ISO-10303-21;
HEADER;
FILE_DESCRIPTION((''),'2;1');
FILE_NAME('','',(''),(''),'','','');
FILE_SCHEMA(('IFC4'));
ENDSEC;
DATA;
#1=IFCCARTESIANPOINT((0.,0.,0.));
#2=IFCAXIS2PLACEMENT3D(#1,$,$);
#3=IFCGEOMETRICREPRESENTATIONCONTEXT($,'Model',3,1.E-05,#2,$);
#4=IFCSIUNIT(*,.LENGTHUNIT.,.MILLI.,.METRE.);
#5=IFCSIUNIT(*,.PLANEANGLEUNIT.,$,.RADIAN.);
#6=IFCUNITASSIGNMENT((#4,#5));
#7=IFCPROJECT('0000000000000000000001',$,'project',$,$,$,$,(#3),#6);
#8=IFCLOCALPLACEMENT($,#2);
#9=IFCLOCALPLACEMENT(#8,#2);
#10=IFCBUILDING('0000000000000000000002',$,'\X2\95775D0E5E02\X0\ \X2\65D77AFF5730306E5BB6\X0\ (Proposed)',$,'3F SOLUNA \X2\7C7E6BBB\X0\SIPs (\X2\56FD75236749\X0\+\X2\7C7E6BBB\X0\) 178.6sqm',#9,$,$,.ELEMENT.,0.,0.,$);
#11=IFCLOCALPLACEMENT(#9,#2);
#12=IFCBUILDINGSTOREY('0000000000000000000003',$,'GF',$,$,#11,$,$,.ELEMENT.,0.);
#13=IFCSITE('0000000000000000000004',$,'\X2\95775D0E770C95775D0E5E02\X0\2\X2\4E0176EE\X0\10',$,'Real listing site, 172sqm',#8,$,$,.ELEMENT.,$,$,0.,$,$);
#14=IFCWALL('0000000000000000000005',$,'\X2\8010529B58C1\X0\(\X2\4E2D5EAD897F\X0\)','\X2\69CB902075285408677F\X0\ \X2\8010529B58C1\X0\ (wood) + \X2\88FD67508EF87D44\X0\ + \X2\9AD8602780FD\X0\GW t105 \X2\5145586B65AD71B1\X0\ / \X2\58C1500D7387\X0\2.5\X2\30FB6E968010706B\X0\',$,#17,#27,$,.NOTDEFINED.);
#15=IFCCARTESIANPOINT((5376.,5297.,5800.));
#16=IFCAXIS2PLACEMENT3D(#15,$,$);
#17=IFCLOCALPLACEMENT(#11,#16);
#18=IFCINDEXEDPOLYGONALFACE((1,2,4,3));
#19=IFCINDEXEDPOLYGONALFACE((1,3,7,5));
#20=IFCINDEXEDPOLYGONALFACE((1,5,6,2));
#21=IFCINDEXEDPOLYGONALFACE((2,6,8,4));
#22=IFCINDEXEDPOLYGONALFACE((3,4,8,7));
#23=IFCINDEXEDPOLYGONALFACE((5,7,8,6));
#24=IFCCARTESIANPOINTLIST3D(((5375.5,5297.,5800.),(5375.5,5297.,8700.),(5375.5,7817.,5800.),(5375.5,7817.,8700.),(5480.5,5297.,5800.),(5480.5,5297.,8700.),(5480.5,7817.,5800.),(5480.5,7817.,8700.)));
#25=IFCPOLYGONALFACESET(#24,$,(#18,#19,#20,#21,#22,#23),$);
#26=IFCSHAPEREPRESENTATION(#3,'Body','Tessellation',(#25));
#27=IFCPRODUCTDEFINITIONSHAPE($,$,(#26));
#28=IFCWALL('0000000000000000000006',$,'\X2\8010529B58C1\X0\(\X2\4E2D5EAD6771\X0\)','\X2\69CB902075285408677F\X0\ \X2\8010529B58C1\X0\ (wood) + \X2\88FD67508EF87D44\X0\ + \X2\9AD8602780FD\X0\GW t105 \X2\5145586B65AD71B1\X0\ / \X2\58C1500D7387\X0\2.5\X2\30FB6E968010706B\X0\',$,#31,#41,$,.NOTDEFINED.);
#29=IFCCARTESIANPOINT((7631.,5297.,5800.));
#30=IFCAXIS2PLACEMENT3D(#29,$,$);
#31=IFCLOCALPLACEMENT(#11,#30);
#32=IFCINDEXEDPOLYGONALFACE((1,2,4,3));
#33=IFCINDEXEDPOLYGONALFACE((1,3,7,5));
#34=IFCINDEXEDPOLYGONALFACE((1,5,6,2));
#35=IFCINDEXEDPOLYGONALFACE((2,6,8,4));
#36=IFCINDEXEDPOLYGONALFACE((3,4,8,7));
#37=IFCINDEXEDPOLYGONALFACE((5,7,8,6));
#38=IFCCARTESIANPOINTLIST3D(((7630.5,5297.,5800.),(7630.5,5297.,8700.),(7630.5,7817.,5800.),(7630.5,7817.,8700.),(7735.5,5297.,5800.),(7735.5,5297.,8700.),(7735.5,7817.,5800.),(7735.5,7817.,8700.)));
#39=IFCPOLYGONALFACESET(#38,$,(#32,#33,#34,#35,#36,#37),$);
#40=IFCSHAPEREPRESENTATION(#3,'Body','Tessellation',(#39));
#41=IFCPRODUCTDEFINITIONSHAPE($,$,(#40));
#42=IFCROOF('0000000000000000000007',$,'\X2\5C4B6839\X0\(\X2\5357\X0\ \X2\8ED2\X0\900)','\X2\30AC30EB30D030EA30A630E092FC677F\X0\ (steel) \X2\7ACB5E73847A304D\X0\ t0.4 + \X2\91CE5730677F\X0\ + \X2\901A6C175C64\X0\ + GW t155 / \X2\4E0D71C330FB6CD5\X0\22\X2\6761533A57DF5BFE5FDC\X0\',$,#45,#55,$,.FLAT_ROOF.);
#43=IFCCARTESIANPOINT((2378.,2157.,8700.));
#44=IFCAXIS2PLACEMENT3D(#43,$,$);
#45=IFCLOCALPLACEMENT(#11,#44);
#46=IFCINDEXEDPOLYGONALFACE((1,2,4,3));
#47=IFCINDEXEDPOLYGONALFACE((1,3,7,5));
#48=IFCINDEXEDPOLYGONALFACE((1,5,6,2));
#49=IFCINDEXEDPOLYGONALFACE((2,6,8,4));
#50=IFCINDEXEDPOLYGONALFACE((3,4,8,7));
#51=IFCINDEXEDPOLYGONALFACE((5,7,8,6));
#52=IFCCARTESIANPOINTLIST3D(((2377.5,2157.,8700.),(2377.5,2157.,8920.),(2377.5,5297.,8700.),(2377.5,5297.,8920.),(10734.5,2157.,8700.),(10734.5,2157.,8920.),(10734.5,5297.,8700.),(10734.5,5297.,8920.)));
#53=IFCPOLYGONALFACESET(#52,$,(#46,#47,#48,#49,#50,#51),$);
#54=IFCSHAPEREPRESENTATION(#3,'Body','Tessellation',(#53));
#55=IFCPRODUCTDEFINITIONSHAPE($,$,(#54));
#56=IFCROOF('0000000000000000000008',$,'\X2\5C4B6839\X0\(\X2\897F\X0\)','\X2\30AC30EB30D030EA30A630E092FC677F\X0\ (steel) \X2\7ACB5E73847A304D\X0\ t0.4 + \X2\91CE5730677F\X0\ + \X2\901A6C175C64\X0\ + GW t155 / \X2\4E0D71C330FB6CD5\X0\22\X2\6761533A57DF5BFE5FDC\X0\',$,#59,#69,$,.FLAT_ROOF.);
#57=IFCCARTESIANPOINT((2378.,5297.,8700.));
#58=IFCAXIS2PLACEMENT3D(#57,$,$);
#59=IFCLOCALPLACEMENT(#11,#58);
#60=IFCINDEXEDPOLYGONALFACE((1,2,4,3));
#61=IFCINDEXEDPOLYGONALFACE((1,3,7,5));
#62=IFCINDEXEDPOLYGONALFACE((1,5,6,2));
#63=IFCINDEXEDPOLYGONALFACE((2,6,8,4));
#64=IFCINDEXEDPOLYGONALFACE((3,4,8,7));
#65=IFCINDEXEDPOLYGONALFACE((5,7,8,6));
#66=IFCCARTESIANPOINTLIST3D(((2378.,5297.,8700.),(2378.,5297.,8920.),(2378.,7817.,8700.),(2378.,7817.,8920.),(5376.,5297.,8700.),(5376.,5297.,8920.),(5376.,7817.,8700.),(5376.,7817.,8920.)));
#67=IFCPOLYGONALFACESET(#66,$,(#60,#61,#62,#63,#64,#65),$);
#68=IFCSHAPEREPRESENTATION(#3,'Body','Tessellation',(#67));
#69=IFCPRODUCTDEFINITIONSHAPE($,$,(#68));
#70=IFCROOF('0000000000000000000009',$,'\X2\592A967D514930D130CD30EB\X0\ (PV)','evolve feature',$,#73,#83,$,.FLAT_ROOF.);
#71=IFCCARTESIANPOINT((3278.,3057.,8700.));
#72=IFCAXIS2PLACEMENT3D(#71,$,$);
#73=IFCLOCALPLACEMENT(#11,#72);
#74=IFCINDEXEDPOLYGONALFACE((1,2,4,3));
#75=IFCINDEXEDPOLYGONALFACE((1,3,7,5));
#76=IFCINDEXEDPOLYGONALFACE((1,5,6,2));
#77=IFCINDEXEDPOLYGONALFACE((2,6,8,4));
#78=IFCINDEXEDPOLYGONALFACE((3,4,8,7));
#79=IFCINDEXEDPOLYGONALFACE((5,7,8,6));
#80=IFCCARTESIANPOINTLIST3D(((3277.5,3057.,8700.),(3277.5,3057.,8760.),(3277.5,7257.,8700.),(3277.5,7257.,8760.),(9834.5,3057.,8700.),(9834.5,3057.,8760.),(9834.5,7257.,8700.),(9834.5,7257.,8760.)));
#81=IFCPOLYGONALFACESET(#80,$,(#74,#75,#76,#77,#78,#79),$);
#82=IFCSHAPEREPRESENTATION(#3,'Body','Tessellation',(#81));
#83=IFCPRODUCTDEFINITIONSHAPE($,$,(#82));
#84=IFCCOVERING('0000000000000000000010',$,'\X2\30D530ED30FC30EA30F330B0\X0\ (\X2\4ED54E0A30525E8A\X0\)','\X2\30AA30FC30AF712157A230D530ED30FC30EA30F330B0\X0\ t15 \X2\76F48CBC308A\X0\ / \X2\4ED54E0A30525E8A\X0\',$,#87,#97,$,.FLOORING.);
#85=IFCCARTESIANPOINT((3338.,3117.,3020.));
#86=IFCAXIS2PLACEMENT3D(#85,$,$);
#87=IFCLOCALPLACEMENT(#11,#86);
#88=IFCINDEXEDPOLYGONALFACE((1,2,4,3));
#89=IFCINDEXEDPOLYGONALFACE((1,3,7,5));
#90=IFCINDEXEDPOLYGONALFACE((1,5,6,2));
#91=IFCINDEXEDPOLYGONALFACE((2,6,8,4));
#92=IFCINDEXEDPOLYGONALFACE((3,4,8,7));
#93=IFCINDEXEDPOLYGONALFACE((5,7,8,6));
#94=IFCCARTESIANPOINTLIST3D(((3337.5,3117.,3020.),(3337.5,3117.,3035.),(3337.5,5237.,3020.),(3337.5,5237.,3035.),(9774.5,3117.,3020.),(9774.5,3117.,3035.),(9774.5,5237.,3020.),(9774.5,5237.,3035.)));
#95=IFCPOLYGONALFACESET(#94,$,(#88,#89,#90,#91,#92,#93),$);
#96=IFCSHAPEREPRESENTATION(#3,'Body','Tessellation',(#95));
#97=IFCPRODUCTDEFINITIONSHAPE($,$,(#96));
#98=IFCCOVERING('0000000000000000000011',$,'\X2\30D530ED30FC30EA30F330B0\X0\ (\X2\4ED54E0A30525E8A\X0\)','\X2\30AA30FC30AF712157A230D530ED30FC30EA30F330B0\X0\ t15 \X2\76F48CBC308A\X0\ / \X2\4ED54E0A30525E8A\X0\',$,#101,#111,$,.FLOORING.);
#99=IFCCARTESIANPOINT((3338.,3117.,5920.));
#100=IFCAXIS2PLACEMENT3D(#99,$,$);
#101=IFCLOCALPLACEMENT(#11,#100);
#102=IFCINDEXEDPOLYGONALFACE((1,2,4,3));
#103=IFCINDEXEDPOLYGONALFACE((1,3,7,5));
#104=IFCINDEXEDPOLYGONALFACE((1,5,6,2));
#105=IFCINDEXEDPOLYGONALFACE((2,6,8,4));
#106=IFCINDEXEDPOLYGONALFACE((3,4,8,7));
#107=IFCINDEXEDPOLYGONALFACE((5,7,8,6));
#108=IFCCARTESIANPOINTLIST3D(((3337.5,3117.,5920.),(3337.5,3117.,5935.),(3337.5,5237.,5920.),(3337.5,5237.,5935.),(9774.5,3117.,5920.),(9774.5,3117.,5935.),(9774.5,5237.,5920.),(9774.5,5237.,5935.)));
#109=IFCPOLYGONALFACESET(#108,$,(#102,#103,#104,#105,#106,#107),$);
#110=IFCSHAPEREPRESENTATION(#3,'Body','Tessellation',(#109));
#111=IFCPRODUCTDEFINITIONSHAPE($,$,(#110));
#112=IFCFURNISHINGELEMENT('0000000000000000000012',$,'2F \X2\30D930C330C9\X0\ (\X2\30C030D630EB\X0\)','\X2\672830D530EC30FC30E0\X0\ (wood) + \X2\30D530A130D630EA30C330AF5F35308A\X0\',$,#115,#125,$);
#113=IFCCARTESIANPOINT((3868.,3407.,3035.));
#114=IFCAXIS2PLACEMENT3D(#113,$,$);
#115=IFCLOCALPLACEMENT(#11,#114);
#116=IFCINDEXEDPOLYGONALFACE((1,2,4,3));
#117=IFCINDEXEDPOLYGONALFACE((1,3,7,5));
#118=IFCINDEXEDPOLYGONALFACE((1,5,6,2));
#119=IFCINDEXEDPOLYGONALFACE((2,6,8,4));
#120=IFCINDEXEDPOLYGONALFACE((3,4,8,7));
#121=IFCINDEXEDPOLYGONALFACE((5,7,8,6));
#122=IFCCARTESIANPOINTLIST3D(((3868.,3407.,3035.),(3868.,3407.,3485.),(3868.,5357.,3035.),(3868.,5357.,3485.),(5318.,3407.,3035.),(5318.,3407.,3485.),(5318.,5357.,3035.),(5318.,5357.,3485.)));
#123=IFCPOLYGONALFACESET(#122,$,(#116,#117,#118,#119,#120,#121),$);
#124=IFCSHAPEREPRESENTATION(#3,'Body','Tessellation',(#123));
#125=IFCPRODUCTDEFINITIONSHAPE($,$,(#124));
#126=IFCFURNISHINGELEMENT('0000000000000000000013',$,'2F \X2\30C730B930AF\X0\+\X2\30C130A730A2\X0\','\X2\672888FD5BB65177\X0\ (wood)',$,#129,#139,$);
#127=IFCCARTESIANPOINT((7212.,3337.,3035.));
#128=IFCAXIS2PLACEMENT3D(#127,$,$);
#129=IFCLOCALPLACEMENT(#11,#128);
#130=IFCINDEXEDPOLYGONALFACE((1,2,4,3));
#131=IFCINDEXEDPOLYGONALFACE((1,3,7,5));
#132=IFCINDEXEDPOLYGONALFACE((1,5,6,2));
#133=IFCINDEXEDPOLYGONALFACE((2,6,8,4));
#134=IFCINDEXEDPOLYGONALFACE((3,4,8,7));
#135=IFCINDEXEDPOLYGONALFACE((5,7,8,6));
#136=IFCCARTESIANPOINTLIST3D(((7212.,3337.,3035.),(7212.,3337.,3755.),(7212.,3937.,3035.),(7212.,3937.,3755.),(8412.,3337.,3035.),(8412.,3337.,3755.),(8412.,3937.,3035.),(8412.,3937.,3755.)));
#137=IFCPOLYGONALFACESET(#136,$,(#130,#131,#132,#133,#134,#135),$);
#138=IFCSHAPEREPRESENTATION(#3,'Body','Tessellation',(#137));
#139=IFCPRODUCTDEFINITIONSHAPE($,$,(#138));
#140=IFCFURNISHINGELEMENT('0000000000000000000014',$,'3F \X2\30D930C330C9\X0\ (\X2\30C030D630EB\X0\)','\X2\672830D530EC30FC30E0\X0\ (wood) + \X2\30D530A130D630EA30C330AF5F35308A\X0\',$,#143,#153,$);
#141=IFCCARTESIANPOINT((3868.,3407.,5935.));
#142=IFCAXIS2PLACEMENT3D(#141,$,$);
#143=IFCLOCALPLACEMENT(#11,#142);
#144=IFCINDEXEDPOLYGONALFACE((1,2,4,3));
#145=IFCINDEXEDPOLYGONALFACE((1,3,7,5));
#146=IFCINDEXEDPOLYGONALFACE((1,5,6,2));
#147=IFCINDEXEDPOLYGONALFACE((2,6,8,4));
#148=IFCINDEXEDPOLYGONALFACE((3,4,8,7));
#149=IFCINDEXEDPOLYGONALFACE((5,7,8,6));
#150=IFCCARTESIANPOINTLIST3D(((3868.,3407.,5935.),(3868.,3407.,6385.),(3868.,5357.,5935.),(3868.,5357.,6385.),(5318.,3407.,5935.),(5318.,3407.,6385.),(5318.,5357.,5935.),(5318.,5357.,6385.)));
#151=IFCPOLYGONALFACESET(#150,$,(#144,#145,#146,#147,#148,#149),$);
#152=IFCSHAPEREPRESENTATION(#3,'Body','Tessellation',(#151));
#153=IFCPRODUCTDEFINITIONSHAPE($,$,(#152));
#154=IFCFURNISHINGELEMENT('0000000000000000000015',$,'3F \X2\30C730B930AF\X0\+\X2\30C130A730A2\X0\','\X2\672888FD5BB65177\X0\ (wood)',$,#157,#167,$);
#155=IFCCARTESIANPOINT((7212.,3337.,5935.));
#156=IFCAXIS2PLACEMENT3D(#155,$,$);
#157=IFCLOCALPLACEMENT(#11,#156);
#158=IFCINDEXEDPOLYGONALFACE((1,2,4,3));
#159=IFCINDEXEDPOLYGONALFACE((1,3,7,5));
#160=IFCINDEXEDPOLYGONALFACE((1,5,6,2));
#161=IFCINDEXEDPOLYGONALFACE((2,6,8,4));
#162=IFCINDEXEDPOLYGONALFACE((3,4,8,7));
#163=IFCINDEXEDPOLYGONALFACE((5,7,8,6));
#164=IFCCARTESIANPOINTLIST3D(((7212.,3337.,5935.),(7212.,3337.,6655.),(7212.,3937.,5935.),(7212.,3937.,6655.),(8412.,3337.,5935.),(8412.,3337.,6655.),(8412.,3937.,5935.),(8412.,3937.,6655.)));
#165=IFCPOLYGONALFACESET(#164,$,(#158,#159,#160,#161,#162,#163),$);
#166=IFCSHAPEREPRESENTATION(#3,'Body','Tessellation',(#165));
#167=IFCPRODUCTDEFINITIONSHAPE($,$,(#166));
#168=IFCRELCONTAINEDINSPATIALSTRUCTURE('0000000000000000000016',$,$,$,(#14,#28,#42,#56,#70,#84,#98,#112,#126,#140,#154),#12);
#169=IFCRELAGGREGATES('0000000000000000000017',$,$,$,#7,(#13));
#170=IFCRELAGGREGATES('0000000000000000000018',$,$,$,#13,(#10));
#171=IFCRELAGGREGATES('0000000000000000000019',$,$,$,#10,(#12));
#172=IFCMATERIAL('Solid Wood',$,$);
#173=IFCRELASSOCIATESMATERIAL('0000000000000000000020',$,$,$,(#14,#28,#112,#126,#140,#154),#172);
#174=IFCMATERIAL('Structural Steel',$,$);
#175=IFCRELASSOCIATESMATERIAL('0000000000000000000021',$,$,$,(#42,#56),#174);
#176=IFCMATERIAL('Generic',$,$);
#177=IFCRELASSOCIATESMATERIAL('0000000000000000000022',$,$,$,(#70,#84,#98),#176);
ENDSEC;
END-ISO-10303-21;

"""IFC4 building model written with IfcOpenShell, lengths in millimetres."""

from ifc_helpers import new_model, si_unit, frame, frame_2d, origin, place, context, project, spatial, rectangle, extrude, material, element, save


model = new_model("IFC4")

# Units and contexts
model_context = context("Model", 3, precision=1e-05, world=origin())
ifc_project = project(units=[si_unit("LENGTHUNIT", "METRE", prefix="MILLI"), si_unit("PLANEANGLEUNIT", "RADIAN")], contexts=[model_context])

# Site, building, storey
site_placement = place(None, origin())
site = spatial("IfcSite", under=ifc_project, at=site_placement, Name="長崎県長崎市2丁目10", ObjectType="Real listing site, 172sqm", CompositionType="ELEMENT", RefElevation=0.0)
building_placement = place(site_placement, origin())
building = spatial("IfcBuilding", under=site, at=building_placement, Name="長崎市 旗竿地の家 (Proposed)", ObjectType="3F SOLUNA 籾殻SIPs (国産杉+籾殻) 178.6sqm", CompositionType="ELEMENT", ElevationOfRefHeight=0.0, ElevationOfTerrain=0.0)
storey_placement = place(building_placement, origin())
storey = spatial("IfcBuildingStorey", under=building, at=storey_placement, Name="GF", CompositionType="ELEMENT", Elevation=0.0)

# Shared definitions
ifc_material_1 = material(Name="Solid Wood")

# Walls
wall_1_placement = place(storey_placement, frame((5376.0, 5297.0, 5800.0)))
element("IfcWall", 1, at=wall_1_placement, inside=storey, material=ifc_material_1, Name="耐力壁(中庭西)", Description="構造用合板 耐力壁 (wood) + 製材軸組 + 高性能GW t105 充填断熱 / 壁倍率2.5・準耐火", PredefinedType="NOTDEFINED", context=model_context, shape_type="SweptSolid", body=[
    extrude(rectangle(XDim=105.0, YDim=2520.0, at=frame_2d((52.0, 1260.0))), frame((5376.0, 5297.0, 5800.0)), (0.0, 0.0, 1.0), 2900.0),
])
wall_2_placement = place(storey_placement, frame((7631.0, 5297.0, 5800.0)))
element("IfcWall", 2, at=wall_2_placement, inside=storey, material=ifc_material_1, Name="耐力壁(中庭東)", Description="構造用合板 耐力壁 (wood) + 製材軸組 + 高性能GW t105 充填断熱 / 壁倍率2.5・準耐火", PredefinedType="NOTDEFINED", context=model_context, shape_type="SweptSolid", body=[
    extrude(rectangle(XDim=105.0, YDim=2520.0, at=frame_2d((52.0, 1260.0))), frame((7631.0, 5297.0, 5800.0)), (0.0, 0.0, 1.0), 2900.0),
])

# Roofs
ifc_material_2 = material(Name="Structural Steel")
roof_1_placement = place(storey_placement, frame((2378.0, 2157.0, 8700.0)))
element("IfcRoof", 3, at=roof_1_placement, inside=storey, material=ifc_material_2, Name="屋根(南 軒900)", Description="ガルバリウム鋼板 (steel) 立平葺き t0.4 + 野地板 + 通気層 + GW t155 / 不燃・法22条区域対応", PredefinedType="FLAT_ROOF", context=model_context, shape_type="SweptSolid", body=[
    extrude(rectangle(XDim=8357.0, YDim=3140.0, at=frame_2d((4178.0, 1570.0))), frame((2378.0, 2157.0, 8700.0)), (0.0, 0.0, 1.0), 220.0),
])
roof_2_placement = place(storey_placement, frame((2378.0, 5297.0, 8700.0)))
element("IfcRoof", 4, at=roof_2_placement, inside=storey, material=ifc_material_2, Name="屋根(西)", Description="ガルバリウム鋼板 (steel) 立平葺き t0.4 + 野地板 + 通気層 + GW t155 / 不燃・法22条区域対応", PredefinedType="FLAT_ROOF", context=model_context, shape_type="SweptSolid", body=[
    extrude(rectangle(XDim=2998.0, YDim=2520.0, at=frame_2d((1499.0, 1260.0))), frame((2378.0, 5297.0, 8700.0)), (0.0, 0.0, 1.0), 220.0),
])
ifc_material_3 = material(Name="Generic")
roof_3_placement = place(storey_placement, frame((3278.0, 3057.0, 8700.0)))
element("IfcRoof", 5, at=roof_3_placement, inside=storey, material=ifc_material_3, Name="太陽光パネル (PV)", Description="evolve feature", PredefinedType="FLAT_ROOF", context=model_context, shape_type="SweptSolid", body=[
    extrude(rectangle(XDim=6557.0, YDim=4200.0, at=frame_2d((3278.0, 2100.0))), frame((3278.0, 3057.0, 8700.0)), (0.0, 0.0, 1.0), 60.0),
])

# Coverings
covering_1_placement = place(storey_placement, frame((3338.0, 3117.0, 3020.0)))
element("IfcCovering", 6, at=covering_1_placement, inside=storey, material=ifc_material_3, Name="フローリング (仕上げ床)", Description="オーク無垢フローリング t15 直貼り / 仕上げ床", PredefinedType="FLOORING", context=model_context, shape_type="SweptSolid", body=[
    extrude(rectangle(XDim=6437.0, YDim=2120.0, at=frame_2d((3218.0, 1060.0))), frame((3338.0, 3117.0, 3020.0)), (0.0, 0.0, 1.0), 15.0),
])
covering_2_placement = place(storey_placement, frame((3338.0, 3117.0, 5920.0)))
element("IfcCovering", 7, at=covering_2_placement, inside=storey, material=ifc_material_3, Name="フローリング (仕上げ床)", Description="オーク無垢フローリング t15 直貼り / 仕上げ床", PredefinedType="FLOORING", context=model_context, shape_type="SweptSolid", body=[
    extrude(rectangle(XDim=6437.0, YDim=2120.0, at=frame_2d((3218.0, 1060.0))), frame((3338.0, 3117.0, 5920.0)), (0.0, 0.0, 1.0), 15.0),
])

# Furnishing elements
furnishing_1_placement = place(storey_placement, frame((3868.0, 3407.0, 3035.0)))
element("IfcFurnishingElement", 8, at=furnishing_1_placement, inside=storey, material=ifc_material_1, Name="2F ベッド (ダブル)", Description="木フレーム (wood) + ファブリック張り", context=model_context, shape_type="SweptSolid", body=[
    extrude(rectangle(XDim=1450.0, YDim=1950.0, at=frame_2d((725.0, 975.0))), frame((3868.0, 3407.0, 3035.0)), (0.0, 0.0, 1.0), 450.0),
])
furnishing_2_placement = place(storey_placement, frame((7212.0, 3337.0, 3035.0)))
element("IfcFurnishingElement", 9, at=furnishing_2_placement, inside=storey, material=ifc_material_1, Name="2F デスク+チェア", Description="木製家具 (wood)", context=model_context, shape_type="SweptSolid", body=[
    extrude(rectangle(XDim=1200.0, YDim=600.0, at=frame_2d((600.0, 300.0))), frame((7212.0, 3337.0, 3035.0)), (0.0, 0.0, 1.0), 720.0),
])
furnishing_3_placement = place(storey_placement, frame((3868.0, 3407.0, 5935.0)))
element("IfcFurnishingElement", 10, at=furnishing_3_placement, inside=storey, material=ifc_material_1, Name="3F ベッド (ダブル)", Description="木フレーム (wood) + ファブリック張り", context=model_context, shape_type="SweptSolid", body=[
    extrude(rectangle(XDim=1450.0, YDim=1950.0, at=frame_2d((725.0, 975.0))), frame((3868.0, 3407.0, 5935.0)), (0.0, 0.0, 1.0), 450.0),
])
furnishing_4_placement = place(storey_placement, frame((7212.0, 3337.0, 5935.0)))
element("IfcFurnishingElement", 11, at=furnishing_4_placement, inside=storey, material=ifc_material_1, Name="3F デスク+チェア", Description="木製家具 (wood)", context=model_context, shape_type="SweptSolid", body=[
    extrude(rectangle(XDim=1200.0, YDim=600.0, at=frame_2d((600.0, 300.0))), frame((7212.0, 3337.0, 5935.0)), (0.0, 0.0, 1.0), 720.0),
])

save(model, "model.ifc")
